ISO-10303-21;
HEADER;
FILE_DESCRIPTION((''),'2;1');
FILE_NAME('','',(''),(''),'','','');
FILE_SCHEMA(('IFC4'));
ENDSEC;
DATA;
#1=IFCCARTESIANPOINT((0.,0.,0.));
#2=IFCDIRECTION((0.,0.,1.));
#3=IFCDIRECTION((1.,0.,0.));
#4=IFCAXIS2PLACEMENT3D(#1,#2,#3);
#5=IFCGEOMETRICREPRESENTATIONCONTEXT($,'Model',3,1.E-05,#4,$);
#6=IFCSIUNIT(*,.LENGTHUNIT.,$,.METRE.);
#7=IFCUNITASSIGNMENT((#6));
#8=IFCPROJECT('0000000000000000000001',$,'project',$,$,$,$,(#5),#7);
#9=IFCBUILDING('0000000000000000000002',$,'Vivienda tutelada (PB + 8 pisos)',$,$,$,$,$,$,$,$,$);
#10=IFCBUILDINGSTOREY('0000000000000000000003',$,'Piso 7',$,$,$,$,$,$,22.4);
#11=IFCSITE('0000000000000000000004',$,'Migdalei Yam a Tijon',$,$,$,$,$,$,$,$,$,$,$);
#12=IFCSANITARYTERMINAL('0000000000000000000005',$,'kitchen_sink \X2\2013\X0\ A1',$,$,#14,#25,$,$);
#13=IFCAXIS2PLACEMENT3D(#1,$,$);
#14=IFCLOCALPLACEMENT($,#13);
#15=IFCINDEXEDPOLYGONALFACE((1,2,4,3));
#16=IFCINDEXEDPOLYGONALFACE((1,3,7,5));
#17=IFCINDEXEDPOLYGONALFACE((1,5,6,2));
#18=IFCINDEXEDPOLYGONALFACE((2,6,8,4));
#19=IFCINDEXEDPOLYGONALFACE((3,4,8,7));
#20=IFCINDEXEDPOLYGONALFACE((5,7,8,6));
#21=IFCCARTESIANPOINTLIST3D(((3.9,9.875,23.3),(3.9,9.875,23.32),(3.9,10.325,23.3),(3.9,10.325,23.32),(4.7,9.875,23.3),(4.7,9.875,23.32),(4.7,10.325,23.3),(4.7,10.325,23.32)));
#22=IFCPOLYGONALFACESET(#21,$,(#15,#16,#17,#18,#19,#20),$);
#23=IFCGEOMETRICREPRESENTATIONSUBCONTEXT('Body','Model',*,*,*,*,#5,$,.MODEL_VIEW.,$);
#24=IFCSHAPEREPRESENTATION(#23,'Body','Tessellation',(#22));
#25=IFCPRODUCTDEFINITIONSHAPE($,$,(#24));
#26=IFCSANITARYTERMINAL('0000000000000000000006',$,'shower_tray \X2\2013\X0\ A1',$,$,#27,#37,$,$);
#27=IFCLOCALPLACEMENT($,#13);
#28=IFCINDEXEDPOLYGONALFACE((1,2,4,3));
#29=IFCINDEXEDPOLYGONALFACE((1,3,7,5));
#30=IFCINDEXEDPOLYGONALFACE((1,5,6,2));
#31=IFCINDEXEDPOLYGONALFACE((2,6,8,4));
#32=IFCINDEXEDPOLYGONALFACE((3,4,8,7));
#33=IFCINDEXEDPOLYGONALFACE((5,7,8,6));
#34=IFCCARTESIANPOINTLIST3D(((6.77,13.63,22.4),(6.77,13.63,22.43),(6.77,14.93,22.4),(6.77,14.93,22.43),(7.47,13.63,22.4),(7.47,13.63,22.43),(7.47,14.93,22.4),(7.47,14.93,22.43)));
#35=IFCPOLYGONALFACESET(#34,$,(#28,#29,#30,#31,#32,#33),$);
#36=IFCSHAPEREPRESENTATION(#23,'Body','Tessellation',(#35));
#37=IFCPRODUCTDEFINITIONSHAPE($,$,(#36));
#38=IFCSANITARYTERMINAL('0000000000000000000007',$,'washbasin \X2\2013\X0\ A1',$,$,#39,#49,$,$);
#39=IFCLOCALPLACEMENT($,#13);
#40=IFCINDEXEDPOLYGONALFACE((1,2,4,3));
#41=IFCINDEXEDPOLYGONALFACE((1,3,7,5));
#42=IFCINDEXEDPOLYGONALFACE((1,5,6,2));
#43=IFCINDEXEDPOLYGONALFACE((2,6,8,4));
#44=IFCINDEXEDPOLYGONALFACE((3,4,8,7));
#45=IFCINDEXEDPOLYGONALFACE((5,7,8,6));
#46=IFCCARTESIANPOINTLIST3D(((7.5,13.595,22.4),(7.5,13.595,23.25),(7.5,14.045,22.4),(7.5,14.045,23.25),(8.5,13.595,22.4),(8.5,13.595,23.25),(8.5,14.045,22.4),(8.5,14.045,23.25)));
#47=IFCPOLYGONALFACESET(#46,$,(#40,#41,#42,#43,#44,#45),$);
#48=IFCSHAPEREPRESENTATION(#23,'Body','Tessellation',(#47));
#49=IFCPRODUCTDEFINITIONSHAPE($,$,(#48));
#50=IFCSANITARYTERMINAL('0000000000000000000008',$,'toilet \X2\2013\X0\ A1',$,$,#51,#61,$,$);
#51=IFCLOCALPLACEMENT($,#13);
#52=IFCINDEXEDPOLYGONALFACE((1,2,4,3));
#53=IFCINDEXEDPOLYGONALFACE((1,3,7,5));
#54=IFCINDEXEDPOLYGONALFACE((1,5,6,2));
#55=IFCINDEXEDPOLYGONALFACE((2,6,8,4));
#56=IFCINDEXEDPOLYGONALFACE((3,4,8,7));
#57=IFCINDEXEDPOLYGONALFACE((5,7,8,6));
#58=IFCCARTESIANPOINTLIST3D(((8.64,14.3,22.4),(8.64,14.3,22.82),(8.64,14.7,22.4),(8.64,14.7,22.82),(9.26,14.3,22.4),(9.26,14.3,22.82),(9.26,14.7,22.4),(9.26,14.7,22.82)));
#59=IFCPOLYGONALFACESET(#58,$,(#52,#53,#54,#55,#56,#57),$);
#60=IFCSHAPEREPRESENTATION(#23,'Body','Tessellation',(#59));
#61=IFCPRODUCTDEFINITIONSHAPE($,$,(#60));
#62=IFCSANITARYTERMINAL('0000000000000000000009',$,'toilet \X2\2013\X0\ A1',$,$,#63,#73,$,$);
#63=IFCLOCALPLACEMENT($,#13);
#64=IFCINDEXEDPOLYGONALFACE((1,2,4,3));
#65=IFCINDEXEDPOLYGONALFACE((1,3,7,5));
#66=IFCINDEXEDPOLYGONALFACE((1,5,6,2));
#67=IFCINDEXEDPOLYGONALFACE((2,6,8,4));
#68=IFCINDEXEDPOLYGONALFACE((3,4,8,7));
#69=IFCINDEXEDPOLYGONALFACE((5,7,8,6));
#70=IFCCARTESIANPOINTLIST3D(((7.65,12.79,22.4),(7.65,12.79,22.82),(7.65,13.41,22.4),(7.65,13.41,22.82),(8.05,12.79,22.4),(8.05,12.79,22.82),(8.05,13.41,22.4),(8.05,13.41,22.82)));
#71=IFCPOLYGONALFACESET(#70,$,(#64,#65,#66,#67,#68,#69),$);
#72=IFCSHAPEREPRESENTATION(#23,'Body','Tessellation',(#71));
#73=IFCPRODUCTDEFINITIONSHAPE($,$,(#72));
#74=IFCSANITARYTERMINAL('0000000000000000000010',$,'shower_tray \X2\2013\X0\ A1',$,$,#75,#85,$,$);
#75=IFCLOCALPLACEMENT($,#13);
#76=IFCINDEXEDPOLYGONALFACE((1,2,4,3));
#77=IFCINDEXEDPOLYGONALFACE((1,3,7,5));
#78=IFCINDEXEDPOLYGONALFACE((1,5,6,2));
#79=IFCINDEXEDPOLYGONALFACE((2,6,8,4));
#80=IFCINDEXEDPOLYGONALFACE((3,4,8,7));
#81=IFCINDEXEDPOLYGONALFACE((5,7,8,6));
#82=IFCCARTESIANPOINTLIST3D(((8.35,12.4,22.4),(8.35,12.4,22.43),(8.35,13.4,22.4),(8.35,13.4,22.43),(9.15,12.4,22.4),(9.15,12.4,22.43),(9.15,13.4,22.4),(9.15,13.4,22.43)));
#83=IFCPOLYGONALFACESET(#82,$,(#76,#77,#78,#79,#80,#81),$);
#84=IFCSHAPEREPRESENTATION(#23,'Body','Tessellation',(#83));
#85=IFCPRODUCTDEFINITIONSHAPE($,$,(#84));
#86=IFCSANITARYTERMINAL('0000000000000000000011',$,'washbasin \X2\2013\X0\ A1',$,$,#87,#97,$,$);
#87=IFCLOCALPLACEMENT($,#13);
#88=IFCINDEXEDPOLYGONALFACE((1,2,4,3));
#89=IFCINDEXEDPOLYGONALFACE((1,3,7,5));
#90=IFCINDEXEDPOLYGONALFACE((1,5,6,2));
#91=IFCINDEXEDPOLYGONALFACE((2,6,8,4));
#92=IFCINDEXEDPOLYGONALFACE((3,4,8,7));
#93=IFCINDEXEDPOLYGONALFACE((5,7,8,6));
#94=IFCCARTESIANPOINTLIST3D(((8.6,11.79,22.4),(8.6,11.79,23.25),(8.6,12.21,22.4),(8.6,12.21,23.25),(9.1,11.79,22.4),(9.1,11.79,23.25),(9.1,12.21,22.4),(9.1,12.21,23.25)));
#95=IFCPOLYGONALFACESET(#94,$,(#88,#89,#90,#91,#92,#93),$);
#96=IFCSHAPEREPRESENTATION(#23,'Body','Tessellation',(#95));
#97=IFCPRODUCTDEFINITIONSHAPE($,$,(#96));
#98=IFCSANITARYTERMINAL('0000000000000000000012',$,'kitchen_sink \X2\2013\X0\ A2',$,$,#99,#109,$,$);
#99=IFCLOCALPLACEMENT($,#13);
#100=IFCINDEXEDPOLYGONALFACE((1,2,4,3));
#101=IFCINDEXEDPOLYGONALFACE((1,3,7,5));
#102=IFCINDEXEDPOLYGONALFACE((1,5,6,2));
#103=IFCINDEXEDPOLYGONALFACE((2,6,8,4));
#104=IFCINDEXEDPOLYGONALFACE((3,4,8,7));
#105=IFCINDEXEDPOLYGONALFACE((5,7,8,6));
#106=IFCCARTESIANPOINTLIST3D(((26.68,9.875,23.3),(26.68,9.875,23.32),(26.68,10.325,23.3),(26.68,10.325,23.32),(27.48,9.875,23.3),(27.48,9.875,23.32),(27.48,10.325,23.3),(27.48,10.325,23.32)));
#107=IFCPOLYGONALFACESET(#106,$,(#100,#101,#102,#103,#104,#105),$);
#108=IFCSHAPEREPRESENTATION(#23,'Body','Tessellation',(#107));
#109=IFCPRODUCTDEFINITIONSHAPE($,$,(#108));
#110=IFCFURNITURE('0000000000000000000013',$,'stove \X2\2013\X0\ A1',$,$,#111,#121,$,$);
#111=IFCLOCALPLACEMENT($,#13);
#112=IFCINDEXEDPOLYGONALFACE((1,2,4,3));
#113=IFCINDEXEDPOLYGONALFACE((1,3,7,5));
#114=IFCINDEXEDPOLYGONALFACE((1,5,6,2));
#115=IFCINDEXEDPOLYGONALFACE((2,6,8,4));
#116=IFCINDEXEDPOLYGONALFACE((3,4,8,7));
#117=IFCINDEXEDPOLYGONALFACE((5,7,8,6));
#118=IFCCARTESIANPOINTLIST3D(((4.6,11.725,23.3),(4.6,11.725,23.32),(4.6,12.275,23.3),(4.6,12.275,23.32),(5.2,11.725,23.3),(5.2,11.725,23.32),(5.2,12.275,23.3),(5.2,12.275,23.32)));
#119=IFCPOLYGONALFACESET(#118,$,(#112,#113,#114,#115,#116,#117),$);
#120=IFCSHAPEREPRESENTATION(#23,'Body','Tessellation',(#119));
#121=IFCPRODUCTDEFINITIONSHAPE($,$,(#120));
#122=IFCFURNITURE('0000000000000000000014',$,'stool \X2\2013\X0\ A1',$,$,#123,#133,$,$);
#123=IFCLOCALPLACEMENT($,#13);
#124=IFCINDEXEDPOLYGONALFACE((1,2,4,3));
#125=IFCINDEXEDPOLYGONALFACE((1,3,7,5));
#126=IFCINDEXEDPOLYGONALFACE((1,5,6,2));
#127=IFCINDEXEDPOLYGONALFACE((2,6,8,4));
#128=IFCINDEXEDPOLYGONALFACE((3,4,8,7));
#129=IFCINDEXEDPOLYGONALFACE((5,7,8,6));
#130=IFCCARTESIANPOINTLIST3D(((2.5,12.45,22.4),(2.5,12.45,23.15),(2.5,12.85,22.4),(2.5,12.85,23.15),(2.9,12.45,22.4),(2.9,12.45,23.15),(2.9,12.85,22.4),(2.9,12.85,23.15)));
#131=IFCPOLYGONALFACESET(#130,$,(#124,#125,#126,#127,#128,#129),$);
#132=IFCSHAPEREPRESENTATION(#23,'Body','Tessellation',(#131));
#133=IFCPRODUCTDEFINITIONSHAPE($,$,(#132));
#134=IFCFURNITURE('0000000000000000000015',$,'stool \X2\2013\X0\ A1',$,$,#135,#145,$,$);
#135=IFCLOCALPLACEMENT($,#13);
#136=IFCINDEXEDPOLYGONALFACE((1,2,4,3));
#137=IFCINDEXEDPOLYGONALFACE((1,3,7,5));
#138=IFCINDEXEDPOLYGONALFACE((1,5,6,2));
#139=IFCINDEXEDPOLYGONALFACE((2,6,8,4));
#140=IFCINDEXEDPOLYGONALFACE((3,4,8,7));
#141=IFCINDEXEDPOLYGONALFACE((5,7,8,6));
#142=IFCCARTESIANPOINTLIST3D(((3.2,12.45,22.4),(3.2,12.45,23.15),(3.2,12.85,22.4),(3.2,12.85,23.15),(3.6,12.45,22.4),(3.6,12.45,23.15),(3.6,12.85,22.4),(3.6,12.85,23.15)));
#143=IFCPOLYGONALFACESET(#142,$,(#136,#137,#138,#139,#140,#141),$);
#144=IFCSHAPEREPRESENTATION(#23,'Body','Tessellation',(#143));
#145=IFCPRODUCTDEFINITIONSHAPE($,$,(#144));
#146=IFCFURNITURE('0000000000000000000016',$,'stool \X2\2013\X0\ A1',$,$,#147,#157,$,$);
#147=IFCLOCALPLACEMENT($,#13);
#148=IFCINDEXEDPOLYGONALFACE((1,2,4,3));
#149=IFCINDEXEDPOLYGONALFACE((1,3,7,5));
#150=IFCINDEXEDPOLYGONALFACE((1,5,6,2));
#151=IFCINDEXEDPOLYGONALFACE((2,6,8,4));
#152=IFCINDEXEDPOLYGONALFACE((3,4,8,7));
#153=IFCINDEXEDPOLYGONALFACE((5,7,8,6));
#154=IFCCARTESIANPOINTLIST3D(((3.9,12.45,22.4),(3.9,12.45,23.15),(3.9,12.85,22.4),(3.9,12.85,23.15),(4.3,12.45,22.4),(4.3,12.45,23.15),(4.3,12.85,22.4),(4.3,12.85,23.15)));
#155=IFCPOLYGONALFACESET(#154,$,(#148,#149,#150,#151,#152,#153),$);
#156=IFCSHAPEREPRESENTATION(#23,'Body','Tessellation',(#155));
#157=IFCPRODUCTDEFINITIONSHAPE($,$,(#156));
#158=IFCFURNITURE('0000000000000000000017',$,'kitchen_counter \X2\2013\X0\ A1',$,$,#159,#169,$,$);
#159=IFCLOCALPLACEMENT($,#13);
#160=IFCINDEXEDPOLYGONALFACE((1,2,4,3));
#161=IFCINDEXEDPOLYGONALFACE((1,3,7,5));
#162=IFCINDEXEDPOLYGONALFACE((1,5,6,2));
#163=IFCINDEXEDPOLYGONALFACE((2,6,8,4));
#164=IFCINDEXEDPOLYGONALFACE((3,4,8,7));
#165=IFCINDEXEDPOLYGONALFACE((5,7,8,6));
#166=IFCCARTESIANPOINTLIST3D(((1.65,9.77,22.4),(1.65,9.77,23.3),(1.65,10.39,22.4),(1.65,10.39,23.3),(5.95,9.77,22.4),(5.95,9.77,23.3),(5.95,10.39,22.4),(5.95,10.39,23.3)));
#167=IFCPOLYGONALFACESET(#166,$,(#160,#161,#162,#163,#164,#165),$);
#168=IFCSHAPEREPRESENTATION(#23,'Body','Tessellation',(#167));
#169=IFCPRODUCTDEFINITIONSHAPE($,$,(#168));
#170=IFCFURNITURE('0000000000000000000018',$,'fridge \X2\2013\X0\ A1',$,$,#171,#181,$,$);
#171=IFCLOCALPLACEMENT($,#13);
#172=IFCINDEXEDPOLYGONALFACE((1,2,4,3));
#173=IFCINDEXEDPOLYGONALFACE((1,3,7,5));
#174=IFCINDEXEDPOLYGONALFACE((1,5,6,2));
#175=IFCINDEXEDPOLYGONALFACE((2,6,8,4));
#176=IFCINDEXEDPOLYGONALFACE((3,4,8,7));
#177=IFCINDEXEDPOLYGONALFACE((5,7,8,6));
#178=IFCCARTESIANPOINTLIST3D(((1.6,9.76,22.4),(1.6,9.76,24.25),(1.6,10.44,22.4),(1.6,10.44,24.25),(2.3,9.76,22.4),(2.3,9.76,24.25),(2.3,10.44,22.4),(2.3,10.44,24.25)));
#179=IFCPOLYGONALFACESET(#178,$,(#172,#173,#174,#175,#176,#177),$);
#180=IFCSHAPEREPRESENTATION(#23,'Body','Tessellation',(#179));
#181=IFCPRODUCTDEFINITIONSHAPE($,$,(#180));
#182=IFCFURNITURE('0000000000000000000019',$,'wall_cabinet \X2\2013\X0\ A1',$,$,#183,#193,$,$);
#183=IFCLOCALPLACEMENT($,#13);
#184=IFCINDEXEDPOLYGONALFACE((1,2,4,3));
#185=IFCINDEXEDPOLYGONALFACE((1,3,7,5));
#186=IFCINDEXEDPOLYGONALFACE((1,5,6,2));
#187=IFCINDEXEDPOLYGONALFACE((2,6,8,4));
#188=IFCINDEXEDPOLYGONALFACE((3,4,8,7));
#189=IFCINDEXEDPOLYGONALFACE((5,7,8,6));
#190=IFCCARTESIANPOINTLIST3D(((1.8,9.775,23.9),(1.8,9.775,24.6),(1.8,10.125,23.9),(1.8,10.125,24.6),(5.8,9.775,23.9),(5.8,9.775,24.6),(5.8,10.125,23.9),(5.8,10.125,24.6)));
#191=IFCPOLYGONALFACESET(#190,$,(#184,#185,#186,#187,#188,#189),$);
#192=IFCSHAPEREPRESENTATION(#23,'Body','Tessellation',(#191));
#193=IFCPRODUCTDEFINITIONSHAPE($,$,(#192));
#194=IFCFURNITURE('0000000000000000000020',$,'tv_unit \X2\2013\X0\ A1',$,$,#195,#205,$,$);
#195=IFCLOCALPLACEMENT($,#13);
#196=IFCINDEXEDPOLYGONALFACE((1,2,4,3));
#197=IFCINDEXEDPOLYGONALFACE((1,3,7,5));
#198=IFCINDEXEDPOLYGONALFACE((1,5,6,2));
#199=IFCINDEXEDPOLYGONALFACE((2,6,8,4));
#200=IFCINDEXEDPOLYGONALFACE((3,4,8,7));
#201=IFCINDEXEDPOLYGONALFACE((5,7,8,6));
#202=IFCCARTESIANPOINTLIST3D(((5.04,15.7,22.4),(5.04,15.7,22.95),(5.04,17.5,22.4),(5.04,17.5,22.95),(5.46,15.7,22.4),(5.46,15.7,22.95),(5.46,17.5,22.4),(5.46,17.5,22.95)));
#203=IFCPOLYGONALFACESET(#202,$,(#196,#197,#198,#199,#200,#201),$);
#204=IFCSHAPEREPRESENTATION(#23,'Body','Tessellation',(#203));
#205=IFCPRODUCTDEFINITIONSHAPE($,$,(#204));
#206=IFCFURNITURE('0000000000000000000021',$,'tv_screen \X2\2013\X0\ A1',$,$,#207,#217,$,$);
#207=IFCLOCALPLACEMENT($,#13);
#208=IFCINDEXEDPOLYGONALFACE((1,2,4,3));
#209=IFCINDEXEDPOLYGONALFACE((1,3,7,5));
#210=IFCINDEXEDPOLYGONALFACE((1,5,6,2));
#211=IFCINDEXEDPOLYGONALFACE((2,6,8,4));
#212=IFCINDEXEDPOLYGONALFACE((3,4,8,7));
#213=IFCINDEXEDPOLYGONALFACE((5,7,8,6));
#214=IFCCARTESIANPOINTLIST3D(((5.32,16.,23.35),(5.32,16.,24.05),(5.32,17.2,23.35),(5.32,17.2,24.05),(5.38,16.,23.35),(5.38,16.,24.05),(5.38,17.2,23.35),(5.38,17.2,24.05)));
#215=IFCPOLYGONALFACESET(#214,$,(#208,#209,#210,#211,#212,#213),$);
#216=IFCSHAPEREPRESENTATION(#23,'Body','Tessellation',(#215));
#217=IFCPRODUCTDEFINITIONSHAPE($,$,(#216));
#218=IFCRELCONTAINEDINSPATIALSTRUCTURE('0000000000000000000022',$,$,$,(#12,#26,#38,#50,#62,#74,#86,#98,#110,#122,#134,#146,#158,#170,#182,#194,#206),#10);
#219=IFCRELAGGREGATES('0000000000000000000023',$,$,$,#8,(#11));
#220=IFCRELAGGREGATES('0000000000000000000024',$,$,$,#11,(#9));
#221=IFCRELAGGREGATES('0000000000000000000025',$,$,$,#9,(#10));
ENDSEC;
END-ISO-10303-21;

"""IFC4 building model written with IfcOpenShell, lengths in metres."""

from ifc_helpers import new_model, si_unit, frame, origin_with_axes, context, subcontext, project, spatial, line, indexed_curve, outline, extrude, element, save


model = new_model("IFC4")

# Units and contexts
model_context = context("Model", 3, precision=1e-05, world=origin_with_axes())
body_context = subcontext(model_context, "Body", "Model", "MODEL_VIEW")
ifc_project = project(units=[si_unit("LENGTHUNIT", "METRE")], contexts=[model_context])

# Site, building, storey
site = spatial("IfcSite", under=ifc_project, Name="Migdalei Yam a Tijon")
building = spatial("IfcBuilding", under=site, Name="Vivienda tutelada (PB + 8 pisos)")
storey = spatial("IfcBuildingStorey", under=building, Name="Piso 7", Elevation=22.4)

# Sanitary terminals
element("IfcSanitaryTerminal", 1, inside=storey, Name="kitchen_sink – A1", context=body_context, shape_type="SweptSolid", body=[
    extrude(outline(indexed_curve([(0.0, 0.0), (0.8, 0.0), (0.8, 0.45), (0.0, 0.45)], segments=[line(1, 2, 3, 4, 1)])), frame((3.9, 9.875, 23.3), z_axis=(0.0, 0.0, 1.0), x_axis=(1.0, 0.0, 0.0)), (0.0, 0.0, 1.0), 0.02),
])
element("IfcSanitaryTerminal", 2, inside=storey, Name="shower_tray – A1", context=body_context, shape_type="SweptSolid", body=[
    extrude(outline(indexed_curve([(0.0, 0.0), (0.7, 0.0), (0.7, 1.3), (0.0, 1.3)], segments=[line(1, 2, 3, 4, 1)])), frame((6.77, 13.63, 22.4), z_axis=(0.0, 0.0, 1.0), x_axis=(1.0, 0.0, 0.0)), (0.0, 0.0, 1.0), 0.03),
])
element("IfcSanitaryTerminal", 3, inside=storey, Name="washbasin – A1", context=body_context, shape_type="SweptSolid", body=[
    extrude(outline(indexed_curve([(0.0, 0.0), (1.0, 0.0), (1.0, 0.45), (0.0, 0.45)], segments=[line(1, 2, 3, 4, 1)])), frame((7.5, 13.595, 22.4), z_axis=(0.0, 0.0, 1.0), x_axis=(1.0, 0.0, 0.0)), (0.0, 0.0, 1.0), 0.85),
])
element("IfcSanitaryTerminal", 4, inside=storey, Name="toilet – A1", context=body_context, shape_type="SweptSolid", body=[
    extrude(outline(indexed_curve([(0.0, 0.0), (0.62, 0.0), (0.62, 0.4), (0.0, 0.4)], segments=[line(1, 2, 3, 4, 1)])), frame((8.64, 14.3, 22.4), z_axis=(0.0, 0.0, 1.0), x_axis=(1.0, 0.0, 0.0)), (0.0, 0.0, 1.0), 0.42),
])
element("IfcSanitaryTerminal", 5, inside=storey, Name="toilet – A1", context=body_context, shape_type="SweptSolid", body=[
    extrude(outline(indexed_curve([(0.0, 0.0), (0.4, 0.0), (0.4, 0.62), (0.0, 0.62)], segments=[line(1, 2, 3, 4, 1)])), frame((7.65, 12.79, 22.4), z_axis=(0.0, 0.0, 1.0), x_axis=(1.0, 0.0, 0.0)), (0.0, 0.0, 1.0), 0.42),
])
element("IfcSanitaryTerminal", 6, inside=storey, Name="shower_tray – A1", context=body_context, shape_type="SweptSolid", body=[
    extrude(outline(indexed_curve([(0.0, 0.0), (0.8, 0.0), (0.8, 1.0), (0.0, 1.0)], segments=[line(1, 2, 3, 4, 1)])), frame((8.35, 12.4, 22.4), z_axis=(0.0, 0.0, 1.0), x_axis=(1.0, 0.0, 0.0)), (0.0, 0.0, 1.0), 0.03),
])
element("IfcSanitaryTerminal", 7, inside=storey, Name="washbasin – A1", context=body_context, shape_type="SweptSolid", body=[
    extrude(outline(indexed_curve([(0.0, 0.0), (0.5, 0.0), (0.5, 0.42), (0.0, 0.42)], segments=[line(1, 2, 3, 4, 1)])), frame((8.6, 11.79, 22.4), z_axis=(0.0, 0.0, 1.0), x_axis=(1.0, 0.0, 0.0)), (0.0, 0.0, 1.0), 0.85),
])
element("IfcSanitaryTerminal", 8, inside=storey, Name="kitchen_sink – A2", context=body_context, shape_type="SweptSolid", body=[
    extrude(outline(indexed_curve([(0.0, 0.0), (0.8, 0.0), (0.8, 0.45), (0.0, 0.45)], segments=[line(1, 2, 3, 4, 1)])), frame((26.68, 9.875, 23.3), z_axis=(0.0, 0.0, 1.0), x_axis=(1.0, 0.0, 0.0)), (0.0, 0.0, 1.0), 0.02),
])

# Furniture
element("IfcFurniture", 9, inside=storey, Name="stove – A1", context=body_context, shape_type="SweptSolid", body=[
    extrude(outline(indexed_curve([(0.0, 0.0), (0.6, 0.0), (0.6, 0.55), (0.0, 0.55)], segments=[line(1, 2, 3, 4, 1)])), frame((4.6, 11.725, 23.3), z_axis=(0.0, 0.0, 1.0), x_axis=(1.0, 0.0, 0.0)), (0.0, 0.0, 1.0), 0.02),
])
element("IfcFurniture", 10, inside=storey, Name="stool – A1", context=body_context, shape_type="SweptSolid", body=[
    extrude(outline(indexed_curve([(0.0, 0.0), (0.4, 0.0), (0.4, 0.4), (0.0, 0.4)], segments=[line(1, 2, 3, 4, 1)])), frame((2.5, 12.45, 22.4), z_axis=(0.0, 0.0, 1.0), x_axis=(1.0, 0.0, 0.0)), (0.0, 0.0, 1.0), 0.75),
])
element("IfcFurniture", 11, inside=storey, Name="stool – A1", context=body_context, shape_type="SweptSolid", body=[
    extrude(outline(indexed_curve([(0.0, 0.0), (0.4, 0.0), (0.4, 0.4), (0.0, 0.4)], segments=[line(1, 2, 3, 4, 1)])), frame((3.2, 12.45, 22.4), z_axis=(0.0, 0.0, 1.0), x_axis=(1.0, 0.0, 0.0)), (0.0, 0.0, 1.0), 0.75),
])
element("IfcFurniture", 12, inside=storey, Name="stool – A1", context=body_context, shape_type="SweptSolid", body=[
    extrude(outline(indexed_curve([(0.0, 0.0), (0.4, 0.0), (0.4, 0.4), (0.0, 0.4)], segments=[line(1, 2, 3, 4, 1)])), frame((3.9, 12.45, 22.4), z_axis=(0.0, 0.0, 1.0), x_axis=(1.0, 0.0, 0.0)), (0.0, 0.0, 1.0), 0.75),
])
element("IfcFurniture", 13, inside=storey, Name="kitchen_counter – A1", context=body_context, shape_type="SweptSolid", body=[
    extrude(outline(indexed_curve([(0.0, 0.0), (4.3, 0.0), (4.3, 0.62), (0.0, 0.62)], segments=[line(1, 2, 3, 4, 1)])), frame((1.65, 9.77, 22.4), z_axis=(0.0, 0.0, 1.0), x_axis=(1.0, 0.0, 0.0)), (0.0, 0.0, 1.0), 0.9),
])
element("IfcFurniture", 14, inside=storey, Name="fridge – A1", context=body_context, shape_type="SweptSolid", body=[
    extrude(outline(indexed_curve([(0.0, 0.0), (0.7, 0.0), (0.7, 0.68), (0.0, 0.68)], segments=[line(1, 2, 3, 4, 1)])), frame((1.6, 9.76, 22.4), z_axis=(0.0, 0.0, 1.0), x_axis=(1.0, 0.0, 0.0)), (0.0, 0.0, 1.0), 1.85),
])
element("IfcFurniture", 15, inside=storey, Name="wall_cabinet – A1", context=body_context, shape_type="SweptSolid", body=[
    extrude(outline(indexed_curve([(0.0, 0.0), (4.0, 0.0), (4.0, 0.35), (0.0, 0.35)], segments=[line(1, 2, 3, 4, 1)])), frame((1.8, 9.775, 23.9), z_axis=(0.0, 0.0, 1.0), x_axis=(1.0, 0.0, 0.0)), (0.0, 0.0, 1.0), 0.7),
])
element("IfcFurniture", 16, inside=storey, Name="tv_unit – A1", context=body_context, shape_type="SweptSolid", body=[
    extrude(outline(indexed_curve([(0.0, 0.0), (0.42, 0.0), (0.42, 1.8), (0.0, 1.8)], segments=[line(1, 2, 3, 4, 1)])), frame((5.04, 15.7, 22.4), z_axis=(0.0, 0.0, 1.0), x_axis=(1.0, 0.0, 0.0)), (0.0, 0.0, 1.0), 0.55),
])
element("IfcFurniture", 17, inside=storey, Name="tv_screen – A1", context=body_context, shape_type="SweptSolid", body=[
    extrude(outline(indexed_curve([(0.0, 0.0), (0.06, 0.0), (0.06, 1.2), (0.0, 1.2)], segments=[line(1, 2, 3, 4, 1)])), frame((5.32, 16.0, 23.35), z_axis=(0.0, 0.0, 1.0), x_axis=(1.0, 0.0, 0.0)), (0.0, 0.0, 1.0), 0.7),
])

save(model, "model.ifc")
